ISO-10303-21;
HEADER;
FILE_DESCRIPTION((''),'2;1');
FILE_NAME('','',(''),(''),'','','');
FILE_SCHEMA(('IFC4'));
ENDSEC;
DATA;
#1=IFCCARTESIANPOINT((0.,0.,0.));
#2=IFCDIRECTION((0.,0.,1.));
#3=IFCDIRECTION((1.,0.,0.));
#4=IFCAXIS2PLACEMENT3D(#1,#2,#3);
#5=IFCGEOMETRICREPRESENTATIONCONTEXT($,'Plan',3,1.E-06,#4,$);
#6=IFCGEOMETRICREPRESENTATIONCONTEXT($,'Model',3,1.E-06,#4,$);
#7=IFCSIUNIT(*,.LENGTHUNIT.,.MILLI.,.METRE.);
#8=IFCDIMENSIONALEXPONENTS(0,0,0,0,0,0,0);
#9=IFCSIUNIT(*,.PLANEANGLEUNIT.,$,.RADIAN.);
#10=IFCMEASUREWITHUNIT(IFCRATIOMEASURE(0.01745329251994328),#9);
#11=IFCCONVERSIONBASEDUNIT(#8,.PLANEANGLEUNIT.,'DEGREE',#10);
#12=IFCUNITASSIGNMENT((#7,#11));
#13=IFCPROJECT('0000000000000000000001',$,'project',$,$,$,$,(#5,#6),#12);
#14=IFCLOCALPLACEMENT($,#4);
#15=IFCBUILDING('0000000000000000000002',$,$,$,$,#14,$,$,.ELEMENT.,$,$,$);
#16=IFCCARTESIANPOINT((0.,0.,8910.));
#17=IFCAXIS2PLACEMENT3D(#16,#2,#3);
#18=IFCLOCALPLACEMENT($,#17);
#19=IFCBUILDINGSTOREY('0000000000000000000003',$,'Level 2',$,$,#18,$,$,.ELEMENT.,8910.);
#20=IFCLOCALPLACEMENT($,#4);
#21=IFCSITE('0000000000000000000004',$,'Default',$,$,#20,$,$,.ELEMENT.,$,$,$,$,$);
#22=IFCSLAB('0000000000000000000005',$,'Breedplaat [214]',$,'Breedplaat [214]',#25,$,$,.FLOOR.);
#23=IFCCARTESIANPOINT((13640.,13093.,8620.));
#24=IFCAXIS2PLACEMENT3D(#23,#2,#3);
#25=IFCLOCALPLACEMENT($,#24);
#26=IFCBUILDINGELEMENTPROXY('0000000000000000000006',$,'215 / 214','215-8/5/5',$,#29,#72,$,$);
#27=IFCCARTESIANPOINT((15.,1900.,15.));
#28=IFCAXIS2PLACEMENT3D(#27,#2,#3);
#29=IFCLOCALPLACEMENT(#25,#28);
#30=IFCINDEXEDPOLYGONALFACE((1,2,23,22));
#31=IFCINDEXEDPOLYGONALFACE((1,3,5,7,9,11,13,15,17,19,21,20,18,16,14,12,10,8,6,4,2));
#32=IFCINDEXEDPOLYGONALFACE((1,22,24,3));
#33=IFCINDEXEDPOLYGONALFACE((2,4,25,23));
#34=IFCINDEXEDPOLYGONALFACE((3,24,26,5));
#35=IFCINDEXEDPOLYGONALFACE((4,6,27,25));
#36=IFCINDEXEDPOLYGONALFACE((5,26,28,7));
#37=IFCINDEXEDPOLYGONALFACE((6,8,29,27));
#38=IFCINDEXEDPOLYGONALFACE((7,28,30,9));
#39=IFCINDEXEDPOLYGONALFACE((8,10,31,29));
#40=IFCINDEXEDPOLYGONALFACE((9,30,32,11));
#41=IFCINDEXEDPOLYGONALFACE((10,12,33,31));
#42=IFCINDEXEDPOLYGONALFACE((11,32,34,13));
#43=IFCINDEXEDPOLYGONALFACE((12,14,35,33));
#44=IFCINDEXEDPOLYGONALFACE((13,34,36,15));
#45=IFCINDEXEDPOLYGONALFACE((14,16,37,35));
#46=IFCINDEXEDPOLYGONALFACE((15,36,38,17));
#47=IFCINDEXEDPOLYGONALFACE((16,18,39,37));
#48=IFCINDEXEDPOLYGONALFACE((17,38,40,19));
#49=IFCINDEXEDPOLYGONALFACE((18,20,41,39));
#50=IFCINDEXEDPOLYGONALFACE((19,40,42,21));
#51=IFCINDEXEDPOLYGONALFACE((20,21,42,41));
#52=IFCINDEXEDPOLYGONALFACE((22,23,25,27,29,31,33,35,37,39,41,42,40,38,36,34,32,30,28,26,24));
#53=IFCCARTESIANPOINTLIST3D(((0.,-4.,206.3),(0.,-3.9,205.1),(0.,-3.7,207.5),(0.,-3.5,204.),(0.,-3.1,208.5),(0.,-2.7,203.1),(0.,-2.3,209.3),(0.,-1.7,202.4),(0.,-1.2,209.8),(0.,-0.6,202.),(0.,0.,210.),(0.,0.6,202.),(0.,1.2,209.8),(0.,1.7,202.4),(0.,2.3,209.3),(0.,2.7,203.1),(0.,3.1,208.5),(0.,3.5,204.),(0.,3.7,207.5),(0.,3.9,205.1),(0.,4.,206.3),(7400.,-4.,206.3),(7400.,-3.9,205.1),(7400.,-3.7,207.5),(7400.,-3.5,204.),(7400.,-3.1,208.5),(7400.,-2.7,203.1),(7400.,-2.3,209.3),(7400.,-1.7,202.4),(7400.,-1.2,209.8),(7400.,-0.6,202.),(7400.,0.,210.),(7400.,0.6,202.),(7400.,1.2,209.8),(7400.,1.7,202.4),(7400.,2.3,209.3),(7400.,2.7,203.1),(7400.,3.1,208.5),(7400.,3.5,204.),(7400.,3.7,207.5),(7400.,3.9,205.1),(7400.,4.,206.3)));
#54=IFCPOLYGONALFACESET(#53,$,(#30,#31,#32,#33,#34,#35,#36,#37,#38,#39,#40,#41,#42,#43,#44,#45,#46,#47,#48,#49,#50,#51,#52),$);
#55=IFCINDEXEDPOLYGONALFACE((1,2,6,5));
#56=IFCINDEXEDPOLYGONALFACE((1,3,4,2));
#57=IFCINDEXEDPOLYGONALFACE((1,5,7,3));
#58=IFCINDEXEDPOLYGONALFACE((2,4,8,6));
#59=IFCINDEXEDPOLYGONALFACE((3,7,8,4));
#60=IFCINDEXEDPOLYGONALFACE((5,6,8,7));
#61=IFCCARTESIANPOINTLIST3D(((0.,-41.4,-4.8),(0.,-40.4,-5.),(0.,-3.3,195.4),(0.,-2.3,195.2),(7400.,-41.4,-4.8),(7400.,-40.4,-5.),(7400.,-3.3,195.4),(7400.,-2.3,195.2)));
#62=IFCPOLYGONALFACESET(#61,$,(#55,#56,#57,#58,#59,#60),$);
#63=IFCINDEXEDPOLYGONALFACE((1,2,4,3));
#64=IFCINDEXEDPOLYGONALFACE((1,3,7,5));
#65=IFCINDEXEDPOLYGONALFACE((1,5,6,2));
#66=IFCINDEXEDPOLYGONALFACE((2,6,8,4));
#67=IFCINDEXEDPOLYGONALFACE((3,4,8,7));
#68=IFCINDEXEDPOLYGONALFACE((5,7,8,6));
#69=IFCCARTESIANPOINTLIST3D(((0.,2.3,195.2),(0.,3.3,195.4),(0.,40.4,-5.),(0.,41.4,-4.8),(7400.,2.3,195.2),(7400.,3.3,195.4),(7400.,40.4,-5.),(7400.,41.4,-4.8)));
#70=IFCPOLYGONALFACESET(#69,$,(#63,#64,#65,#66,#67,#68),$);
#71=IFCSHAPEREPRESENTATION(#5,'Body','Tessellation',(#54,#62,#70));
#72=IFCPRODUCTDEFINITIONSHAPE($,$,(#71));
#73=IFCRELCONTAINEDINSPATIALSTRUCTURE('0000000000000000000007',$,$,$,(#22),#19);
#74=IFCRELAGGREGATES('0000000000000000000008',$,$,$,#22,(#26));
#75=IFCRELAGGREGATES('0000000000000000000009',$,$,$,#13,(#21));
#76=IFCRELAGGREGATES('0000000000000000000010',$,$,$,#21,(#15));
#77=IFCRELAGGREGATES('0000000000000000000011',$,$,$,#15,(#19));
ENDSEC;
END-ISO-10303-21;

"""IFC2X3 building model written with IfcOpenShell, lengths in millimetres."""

from ifc_helpers import new_model, entity, si_unit, converted_unit, frame, origin_with_axes, origin_2d_with_axis, place, context, project, spatial, rectangle, circle, extrude, element, aggregate, save


model = new_model("IFC2X3")

# Units and contexts
plan_context = context("Plan", 3, precision=1e-06, world=origin_with_axes())
model_context = context("Model", 3, precision=1e-06, world=origin_with_axes())
ifc_project = project(units=[si_unit("LENGTHUNIT", "METRE", prefix="MILLI"), converted_unit("PLANEANGLEUNIT", "DEGREE", entity("IfcRatioMeasure", 0.01745329251994328), si_unit("PLANEANGLEUNIT", "RADIAN"), dimensions=[0, 0, 0, 0, 0, 0, 0])], contexts=[plan_context, model_context])

# Site, building, storey
site_placement = place(None, origin_with_axes())
site = spatial("IfcSite", under=ifc_project, at=site_placement, Name="Default", CompositionType="ELEMENT")
building_placement = place(None, origin_with_axes())
building = spatial("IfcBuilding", under=site, at=building_placement, CompositionType="ELEMENT")
storey_placement = place(None, frame((0.0, 0.0, 8910.0), z_axis=(0.0, 0.0, 1.0), x_axis=(1.0, 0.0, 0.0)))
storey = spatial("IfcBuildingStorey", under=building, at=storey_placement, Name="Level 2", CompositionType="ELEMENT", Elevation=8910.0)

# Slab, building element proxy
slab_1_placement = place(None, frame((13640.0, 13093.0, 8620.0), z_axis=(0.0, 0.0, 1.0), x_axis=(1.0, 0.0, 0.0)))
slab_1 = element("IfcSlab", 1, at=slab_1_placement, inside=storey, Name="Breedplaat [214]", ObjectType="Breedplaat [214]", PredefinedType="FLOOR")
proxy_1_placement = place(slab_1_placement, frame((15.0, 1900.0, 15.0), z_axis=(0.0, 0.0, 1.0), x_axis=(1.0, 0.0, 0.0)))
proxy_1 = element("IfcBuildingElementProxy", 2, at=proxy_1_placement, Name="215 / 214", Description="215-8/5/5", context=plan_context, shape_type="SweptSolid", body=[
    extrude(circle(Radius=4.0, at=origin_2d_with_axis()), frame((0.0, 0.0, 206.0), z_axis=(1.0, 0.0, 0.0), x_axis=(0.0, 0.0, 1.0)), (0.0, 0.0, 1.0), 7400.0),
    extrude(rectangle(XDim=203.8, YDim=1.0, at=origin_2d_with_axis()), frame((0.0, -21.9, 95.2), z_axis=(1.0, 0.0, 0.0), x_axis=(0.0, 0.187112, 0.982339)), (0.0, 0.0, 1.0), 7400.0),
    extrude(rectangle(XDim=203.8, YDim=1.0, at=origin_2d_with_axis()), frame((0.0, 21.9, 95.2), z_axis=(1.0, 0.0, 0.0), x_axis=(0.0, -0.187112, 0.982339)), (0.0, 0.0, 1.0), 7400.0),
])
aggregate(slab_1, [proxy_1])

save(model, "model.ifc")
